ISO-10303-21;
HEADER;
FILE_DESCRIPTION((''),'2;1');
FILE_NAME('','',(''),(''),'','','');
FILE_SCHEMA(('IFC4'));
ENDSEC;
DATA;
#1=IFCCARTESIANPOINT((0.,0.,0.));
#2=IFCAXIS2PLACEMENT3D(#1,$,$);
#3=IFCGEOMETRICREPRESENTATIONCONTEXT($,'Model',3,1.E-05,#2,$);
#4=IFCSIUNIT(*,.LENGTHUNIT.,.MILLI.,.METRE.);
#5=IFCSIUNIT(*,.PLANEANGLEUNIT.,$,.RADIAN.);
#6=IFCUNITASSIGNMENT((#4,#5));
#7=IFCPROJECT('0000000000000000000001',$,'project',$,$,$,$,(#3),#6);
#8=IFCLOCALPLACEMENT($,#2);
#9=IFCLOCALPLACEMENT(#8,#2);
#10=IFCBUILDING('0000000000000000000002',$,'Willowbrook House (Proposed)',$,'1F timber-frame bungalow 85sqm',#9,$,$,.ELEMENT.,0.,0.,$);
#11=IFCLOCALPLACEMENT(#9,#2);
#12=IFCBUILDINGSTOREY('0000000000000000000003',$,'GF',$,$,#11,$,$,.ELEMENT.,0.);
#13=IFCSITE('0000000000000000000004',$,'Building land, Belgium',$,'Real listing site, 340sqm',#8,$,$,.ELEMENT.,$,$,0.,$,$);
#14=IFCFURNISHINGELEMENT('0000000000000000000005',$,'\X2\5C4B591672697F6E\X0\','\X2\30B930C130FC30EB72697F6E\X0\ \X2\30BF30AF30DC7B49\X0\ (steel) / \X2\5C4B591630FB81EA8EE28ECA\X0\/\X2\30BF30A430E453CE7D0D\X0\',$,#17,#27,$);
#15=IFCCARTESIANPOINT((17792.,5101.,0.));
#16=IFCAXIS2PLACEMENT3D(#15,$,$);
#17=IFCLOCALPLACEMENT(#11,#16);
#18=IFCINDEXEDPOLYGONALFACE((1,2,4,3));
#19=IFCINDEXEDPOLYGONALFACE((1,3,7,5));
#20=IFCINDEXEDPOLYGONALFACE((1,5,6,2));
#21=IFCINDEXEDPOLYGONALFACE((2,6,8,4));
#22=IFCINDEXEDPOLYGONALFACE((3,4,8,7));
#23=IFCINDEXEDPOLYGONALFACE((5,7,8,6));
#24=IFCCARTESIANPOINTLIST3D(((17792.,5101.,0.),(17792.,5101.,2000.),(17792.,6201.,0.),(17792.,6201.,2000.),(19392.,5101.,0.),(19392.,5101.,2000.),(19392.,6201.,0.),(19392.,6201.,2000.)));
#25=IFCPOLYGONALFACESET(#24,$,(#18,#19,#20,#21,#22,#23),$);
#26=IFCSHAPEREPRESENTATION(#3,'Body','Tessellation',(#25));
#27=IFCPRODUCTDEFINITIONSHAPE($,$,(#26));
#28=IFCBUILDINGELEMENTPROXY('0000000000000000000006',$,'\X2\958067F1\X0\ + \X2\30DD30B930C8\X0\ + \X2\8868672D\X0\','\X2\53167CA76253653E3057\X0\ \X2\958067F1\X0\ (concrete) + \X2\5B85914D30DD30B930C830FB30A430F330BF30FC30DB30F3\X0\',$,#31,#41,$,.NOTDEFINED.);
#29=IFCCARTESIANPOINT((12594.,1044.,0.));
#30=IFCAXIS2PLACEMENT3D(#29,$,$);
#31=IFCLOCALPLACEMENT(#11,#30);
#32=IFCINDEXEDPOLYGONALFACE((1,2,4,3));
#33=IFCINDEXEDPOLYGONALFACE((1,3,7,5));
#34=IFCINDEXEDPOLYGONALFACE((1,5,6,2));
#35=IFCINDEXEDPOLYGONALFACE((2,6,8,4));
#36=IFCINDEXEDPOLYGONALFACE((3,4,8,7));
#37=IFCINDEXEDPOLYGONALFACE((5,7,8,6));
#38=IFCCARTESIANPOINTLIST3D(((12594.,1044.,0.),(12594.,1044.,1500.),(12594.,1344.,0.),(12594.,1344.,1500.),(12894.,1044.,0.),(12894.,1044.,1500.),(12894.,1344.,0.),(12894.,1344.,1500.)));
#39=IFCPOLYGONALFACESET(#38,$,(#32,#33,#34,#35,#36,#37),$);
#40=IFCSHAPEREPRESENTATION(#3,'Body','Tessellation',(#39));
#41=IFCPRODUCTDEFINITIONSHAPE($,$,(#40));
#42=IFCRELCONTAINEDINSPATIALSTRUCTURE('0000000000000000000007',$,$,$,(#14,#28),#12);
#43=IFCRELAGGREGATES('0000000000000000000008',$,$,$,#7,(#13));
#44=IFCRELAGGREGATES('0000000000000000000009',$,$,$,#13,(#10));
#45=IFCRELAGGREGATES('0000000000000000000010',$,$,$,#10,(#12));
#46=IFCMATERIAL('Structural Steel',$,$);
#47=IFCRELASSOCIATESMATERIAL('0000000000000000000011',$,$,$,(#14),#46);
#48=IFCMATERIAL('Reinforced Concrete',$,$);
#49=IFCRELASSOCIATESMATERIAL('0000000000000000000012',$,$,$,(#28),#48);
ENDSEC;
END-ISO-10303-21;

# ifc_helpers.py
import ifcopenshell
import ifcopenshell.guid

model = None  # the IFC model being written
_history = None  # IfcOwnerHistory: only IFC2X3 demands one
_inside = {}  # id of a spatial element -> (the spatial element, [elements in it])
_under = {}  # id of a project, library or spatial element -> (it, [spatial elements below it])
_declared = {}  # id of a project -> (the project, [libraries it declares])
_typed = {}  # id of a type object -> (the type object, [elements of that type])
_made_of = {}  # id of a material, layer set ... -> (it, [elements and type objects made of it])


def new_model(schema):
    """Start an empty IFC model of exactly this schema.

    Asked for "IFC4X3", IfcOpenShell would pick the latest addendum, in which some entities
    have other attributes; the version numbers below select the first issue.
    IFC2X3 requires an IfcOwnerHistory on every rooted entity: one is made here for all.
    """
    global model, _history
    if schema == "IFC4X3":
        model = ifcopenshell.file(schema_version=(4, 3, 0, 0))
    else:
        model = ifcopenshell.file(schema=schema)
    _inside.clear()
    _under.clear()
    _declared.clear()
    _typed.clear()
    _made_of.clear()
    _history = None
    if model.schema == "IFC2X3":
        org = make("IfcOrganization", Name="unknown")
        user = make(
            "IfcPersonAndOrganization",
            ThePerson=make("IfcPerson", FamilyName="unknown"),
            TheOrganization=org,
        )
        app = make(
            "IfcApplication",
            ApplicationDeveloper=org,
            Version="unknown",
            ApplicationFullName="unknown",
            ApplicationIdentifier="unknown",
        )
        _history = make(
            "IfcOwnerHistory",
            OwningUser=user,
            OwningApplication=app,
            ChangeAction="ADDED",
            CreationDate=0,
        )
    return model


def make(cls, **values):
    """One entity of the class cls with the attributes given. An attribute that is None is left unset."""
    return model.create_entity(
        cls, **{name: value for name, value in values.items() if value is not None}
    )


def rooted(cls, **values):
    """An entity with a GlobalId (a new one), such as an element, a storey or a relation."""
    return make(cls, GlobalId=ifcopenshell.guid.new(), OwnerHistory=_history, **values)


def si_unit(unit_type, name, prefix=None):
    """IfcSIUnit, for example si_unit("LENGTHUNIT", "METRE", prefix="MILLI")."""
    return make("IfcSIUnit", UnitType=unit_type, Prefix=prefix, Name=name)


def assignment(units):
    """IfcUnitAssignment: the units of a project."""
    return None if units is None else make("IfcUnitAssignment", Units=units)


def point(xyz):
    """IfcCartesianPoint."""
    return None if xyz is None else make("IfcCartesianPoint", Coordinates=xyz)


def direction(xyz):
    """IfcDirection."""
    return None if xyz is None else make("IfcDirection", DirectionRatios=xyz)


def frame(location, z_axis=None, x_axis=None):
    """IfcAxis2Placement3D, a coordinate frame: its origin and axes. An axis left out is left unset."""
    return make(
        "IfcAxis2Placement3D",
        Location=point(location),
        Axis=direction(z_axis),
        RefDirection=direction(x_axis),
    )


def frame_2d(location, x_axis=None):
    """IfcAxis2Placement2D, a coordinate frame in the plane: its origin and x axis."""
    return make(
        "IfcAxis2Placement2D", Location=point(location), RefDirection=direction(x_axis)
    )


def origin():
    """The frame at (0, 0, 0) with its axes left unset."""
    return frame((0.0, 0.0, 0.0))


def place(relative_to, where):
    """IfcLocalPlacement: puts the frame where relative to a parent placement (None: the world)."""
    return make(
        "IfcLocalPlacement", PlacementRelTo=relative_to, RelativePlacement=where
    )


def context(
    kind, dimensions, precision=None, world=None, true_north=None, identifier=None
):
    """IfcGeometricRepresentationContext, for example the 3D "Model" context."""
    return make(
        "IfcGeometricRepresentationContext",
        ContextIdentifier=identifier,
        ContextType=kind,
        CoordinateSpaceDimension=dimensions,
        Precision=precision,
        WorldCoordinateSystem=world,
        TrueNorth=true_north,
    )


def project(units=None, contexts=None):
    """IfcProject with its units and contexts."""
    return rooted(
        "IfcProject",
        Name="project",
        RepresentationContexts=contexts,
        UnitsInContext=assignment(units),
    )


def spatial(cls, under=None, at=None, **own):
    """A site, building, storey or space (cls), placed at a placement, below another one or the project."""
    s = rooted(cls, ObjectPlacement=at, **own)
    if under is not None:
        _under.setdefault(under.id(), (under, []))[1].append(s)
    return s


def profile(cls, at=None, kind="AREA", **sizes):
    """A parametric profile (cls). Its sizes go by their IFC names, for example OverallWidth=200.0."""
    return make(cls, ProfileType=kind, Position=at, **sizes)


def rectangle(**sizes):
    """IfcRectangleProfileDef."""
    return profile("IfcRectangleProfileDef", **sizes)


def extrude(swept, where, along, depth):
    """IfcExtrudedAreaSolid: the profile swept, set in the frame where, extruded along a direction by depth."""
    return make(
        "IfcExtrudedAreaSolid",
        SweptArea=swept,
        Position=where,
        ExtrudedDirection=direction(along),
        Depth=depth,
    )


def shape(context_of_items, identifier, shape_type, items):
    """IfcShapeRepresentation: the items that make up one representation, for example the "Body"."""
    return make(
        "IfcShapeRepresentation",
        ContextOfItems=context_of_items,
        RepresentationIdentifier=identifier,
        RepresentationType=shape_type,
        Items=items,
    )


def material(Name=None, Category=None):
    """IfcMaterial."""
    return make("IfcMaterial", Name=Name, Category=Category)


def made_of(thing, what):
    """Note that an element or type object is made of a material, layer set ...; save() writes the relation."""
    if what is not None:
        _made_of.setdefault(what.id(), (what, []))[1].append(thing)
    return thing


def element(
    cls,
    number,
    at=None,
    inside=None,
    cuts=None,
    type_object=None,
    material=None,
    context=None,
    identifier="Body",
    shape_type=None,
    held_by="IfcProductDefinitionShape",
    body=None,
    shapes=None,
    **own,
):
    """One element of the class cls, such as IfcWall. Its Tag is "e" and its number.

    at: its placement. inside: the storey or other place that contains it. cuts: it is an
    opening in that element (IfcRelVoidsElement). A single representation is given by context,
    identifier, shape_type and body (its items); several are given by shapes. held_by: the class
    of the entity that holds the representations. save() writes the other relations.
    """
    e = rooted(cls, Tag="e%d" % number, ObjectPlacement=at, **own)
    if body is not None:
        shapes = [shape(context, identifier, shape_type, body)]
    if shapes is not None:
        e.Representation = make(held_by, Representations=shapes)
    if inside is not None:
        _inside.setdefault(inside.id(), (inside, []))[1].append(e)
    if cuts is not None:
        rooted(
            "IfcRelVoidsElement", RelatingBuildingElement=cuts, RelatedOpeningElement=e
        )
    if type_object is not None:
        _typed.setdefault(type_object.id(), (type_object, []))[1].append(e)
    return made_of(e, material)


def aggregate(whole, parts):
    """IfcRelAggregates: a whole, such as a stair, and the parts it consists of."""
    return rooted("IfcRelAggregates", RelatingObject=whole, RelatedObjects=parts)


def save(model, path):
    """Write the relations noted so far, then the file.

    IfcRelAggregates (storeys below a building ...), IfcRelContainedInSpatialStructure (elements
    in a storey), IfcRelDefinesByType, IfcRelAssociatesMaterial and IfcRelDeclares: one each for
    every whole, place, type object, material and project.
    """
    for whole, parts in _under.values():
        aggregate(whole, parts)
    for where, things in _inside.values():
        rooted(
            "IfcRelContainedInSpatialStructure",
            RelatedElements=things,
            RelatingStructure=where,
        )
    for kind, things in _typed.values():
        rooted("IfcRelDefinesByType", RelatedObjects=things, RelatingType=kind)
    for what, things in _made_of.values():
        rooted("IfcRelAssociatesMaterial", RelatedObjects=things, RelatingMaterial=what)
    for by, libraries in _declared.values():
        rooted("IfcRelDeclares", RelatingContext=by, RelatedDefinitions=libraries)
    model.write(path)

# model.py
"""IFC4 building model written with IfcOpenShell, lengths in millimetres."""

from ifc_helpers import new_model, si_unit, frame, frame_2d, origin, place, context, project, spatial, rectangle, extrude, material, element, save


model = new_model("IFC4")

# Units and contexts
model_context = context("Model", 3, precision=1e-05, world=origin())
ifc_project = project(units=[si_unit("LENGTHUNIT", "METRE", prefix="MILLI"), si_unit("PLANEANGLEUNIT", "RADIAN")], contexts=[model_context])

# Site, building, storey
site_placement = place(None, origin())
site = spatial("IfcSite", under=ifc_project, at=site_placement, Name="Building land, Belgium", ObjectType="Real listing site, 340sqm", CompositionType="ELEMENT", RefElevation=0.0)
building_placement = place(site_placement, origin())
building = spatial("IfcBuilding", under=site, at=building_placement, Name="Willowbrook House (Proposed)", ObjectType="1F timber-frame bungalow 85sqm", CompositionType="ELEMENT", ElevationOfRefHeight=0.0, ElevationOfTerrain=0.0)
storey_placement = place(building_placement, origin())
storey = spatial("IfcBuildingStorey", under=building, at=storey_placement, Name="GF", CompositionType="ELEMENT", Elevation=0.0)

# Shared definitions
ifc_material_1 = material(Name="Structural Steel")

# Shared definitions
ifc_material_2 = material(Name="Reinforced Concrete")

# Furnishing element
furnishing_1_placement = place(storey_placement, frame((17792.0, 5101.0, 0.0)))
element("IfcFurnishingElement", 1, at=furnishing_1_placement, inside=storey, material=ifc_material_1, Name="屋外物置", Description="スチール物置 タクボ等 (steel) / 屋外・自転車/タイヤ収納", context=model_context, shape_type="SweptSolid", body=[
    extrude(rectangle(XDim=1600.0, YDim=1100.0, at=frame_2d((800.0, 550.0))), frame((17792.0, 5101.0, 0.0)), (0.0, 0.0, 1.0), 2000.0),
])

# Building element proxy
proxy_placement = place(storey_placement, frame((12594.0, 1044.0, 0.0)))
element("IfcBuildingElementProxy", 2, at=proxy_placement, inside=storey, material=ifc_material_2, Name="門柱 + ポスト + 表札", Description="化粧打放し 門柱 (concrete) + 宅配ポスト・インターホン", PredefinedType="NOTDEFINED", context=model_context, shape_type="SweptSolid", body=[
    extrude(rectangle(XDim=300.0, YDim=300.0, at=frame_2d((150.0, 150.0))), frame((12594.0, 1044.0, 0.0)), (0.0, 0.0, 1.0), 1500.0),
])

save(model, "model.ifc")
